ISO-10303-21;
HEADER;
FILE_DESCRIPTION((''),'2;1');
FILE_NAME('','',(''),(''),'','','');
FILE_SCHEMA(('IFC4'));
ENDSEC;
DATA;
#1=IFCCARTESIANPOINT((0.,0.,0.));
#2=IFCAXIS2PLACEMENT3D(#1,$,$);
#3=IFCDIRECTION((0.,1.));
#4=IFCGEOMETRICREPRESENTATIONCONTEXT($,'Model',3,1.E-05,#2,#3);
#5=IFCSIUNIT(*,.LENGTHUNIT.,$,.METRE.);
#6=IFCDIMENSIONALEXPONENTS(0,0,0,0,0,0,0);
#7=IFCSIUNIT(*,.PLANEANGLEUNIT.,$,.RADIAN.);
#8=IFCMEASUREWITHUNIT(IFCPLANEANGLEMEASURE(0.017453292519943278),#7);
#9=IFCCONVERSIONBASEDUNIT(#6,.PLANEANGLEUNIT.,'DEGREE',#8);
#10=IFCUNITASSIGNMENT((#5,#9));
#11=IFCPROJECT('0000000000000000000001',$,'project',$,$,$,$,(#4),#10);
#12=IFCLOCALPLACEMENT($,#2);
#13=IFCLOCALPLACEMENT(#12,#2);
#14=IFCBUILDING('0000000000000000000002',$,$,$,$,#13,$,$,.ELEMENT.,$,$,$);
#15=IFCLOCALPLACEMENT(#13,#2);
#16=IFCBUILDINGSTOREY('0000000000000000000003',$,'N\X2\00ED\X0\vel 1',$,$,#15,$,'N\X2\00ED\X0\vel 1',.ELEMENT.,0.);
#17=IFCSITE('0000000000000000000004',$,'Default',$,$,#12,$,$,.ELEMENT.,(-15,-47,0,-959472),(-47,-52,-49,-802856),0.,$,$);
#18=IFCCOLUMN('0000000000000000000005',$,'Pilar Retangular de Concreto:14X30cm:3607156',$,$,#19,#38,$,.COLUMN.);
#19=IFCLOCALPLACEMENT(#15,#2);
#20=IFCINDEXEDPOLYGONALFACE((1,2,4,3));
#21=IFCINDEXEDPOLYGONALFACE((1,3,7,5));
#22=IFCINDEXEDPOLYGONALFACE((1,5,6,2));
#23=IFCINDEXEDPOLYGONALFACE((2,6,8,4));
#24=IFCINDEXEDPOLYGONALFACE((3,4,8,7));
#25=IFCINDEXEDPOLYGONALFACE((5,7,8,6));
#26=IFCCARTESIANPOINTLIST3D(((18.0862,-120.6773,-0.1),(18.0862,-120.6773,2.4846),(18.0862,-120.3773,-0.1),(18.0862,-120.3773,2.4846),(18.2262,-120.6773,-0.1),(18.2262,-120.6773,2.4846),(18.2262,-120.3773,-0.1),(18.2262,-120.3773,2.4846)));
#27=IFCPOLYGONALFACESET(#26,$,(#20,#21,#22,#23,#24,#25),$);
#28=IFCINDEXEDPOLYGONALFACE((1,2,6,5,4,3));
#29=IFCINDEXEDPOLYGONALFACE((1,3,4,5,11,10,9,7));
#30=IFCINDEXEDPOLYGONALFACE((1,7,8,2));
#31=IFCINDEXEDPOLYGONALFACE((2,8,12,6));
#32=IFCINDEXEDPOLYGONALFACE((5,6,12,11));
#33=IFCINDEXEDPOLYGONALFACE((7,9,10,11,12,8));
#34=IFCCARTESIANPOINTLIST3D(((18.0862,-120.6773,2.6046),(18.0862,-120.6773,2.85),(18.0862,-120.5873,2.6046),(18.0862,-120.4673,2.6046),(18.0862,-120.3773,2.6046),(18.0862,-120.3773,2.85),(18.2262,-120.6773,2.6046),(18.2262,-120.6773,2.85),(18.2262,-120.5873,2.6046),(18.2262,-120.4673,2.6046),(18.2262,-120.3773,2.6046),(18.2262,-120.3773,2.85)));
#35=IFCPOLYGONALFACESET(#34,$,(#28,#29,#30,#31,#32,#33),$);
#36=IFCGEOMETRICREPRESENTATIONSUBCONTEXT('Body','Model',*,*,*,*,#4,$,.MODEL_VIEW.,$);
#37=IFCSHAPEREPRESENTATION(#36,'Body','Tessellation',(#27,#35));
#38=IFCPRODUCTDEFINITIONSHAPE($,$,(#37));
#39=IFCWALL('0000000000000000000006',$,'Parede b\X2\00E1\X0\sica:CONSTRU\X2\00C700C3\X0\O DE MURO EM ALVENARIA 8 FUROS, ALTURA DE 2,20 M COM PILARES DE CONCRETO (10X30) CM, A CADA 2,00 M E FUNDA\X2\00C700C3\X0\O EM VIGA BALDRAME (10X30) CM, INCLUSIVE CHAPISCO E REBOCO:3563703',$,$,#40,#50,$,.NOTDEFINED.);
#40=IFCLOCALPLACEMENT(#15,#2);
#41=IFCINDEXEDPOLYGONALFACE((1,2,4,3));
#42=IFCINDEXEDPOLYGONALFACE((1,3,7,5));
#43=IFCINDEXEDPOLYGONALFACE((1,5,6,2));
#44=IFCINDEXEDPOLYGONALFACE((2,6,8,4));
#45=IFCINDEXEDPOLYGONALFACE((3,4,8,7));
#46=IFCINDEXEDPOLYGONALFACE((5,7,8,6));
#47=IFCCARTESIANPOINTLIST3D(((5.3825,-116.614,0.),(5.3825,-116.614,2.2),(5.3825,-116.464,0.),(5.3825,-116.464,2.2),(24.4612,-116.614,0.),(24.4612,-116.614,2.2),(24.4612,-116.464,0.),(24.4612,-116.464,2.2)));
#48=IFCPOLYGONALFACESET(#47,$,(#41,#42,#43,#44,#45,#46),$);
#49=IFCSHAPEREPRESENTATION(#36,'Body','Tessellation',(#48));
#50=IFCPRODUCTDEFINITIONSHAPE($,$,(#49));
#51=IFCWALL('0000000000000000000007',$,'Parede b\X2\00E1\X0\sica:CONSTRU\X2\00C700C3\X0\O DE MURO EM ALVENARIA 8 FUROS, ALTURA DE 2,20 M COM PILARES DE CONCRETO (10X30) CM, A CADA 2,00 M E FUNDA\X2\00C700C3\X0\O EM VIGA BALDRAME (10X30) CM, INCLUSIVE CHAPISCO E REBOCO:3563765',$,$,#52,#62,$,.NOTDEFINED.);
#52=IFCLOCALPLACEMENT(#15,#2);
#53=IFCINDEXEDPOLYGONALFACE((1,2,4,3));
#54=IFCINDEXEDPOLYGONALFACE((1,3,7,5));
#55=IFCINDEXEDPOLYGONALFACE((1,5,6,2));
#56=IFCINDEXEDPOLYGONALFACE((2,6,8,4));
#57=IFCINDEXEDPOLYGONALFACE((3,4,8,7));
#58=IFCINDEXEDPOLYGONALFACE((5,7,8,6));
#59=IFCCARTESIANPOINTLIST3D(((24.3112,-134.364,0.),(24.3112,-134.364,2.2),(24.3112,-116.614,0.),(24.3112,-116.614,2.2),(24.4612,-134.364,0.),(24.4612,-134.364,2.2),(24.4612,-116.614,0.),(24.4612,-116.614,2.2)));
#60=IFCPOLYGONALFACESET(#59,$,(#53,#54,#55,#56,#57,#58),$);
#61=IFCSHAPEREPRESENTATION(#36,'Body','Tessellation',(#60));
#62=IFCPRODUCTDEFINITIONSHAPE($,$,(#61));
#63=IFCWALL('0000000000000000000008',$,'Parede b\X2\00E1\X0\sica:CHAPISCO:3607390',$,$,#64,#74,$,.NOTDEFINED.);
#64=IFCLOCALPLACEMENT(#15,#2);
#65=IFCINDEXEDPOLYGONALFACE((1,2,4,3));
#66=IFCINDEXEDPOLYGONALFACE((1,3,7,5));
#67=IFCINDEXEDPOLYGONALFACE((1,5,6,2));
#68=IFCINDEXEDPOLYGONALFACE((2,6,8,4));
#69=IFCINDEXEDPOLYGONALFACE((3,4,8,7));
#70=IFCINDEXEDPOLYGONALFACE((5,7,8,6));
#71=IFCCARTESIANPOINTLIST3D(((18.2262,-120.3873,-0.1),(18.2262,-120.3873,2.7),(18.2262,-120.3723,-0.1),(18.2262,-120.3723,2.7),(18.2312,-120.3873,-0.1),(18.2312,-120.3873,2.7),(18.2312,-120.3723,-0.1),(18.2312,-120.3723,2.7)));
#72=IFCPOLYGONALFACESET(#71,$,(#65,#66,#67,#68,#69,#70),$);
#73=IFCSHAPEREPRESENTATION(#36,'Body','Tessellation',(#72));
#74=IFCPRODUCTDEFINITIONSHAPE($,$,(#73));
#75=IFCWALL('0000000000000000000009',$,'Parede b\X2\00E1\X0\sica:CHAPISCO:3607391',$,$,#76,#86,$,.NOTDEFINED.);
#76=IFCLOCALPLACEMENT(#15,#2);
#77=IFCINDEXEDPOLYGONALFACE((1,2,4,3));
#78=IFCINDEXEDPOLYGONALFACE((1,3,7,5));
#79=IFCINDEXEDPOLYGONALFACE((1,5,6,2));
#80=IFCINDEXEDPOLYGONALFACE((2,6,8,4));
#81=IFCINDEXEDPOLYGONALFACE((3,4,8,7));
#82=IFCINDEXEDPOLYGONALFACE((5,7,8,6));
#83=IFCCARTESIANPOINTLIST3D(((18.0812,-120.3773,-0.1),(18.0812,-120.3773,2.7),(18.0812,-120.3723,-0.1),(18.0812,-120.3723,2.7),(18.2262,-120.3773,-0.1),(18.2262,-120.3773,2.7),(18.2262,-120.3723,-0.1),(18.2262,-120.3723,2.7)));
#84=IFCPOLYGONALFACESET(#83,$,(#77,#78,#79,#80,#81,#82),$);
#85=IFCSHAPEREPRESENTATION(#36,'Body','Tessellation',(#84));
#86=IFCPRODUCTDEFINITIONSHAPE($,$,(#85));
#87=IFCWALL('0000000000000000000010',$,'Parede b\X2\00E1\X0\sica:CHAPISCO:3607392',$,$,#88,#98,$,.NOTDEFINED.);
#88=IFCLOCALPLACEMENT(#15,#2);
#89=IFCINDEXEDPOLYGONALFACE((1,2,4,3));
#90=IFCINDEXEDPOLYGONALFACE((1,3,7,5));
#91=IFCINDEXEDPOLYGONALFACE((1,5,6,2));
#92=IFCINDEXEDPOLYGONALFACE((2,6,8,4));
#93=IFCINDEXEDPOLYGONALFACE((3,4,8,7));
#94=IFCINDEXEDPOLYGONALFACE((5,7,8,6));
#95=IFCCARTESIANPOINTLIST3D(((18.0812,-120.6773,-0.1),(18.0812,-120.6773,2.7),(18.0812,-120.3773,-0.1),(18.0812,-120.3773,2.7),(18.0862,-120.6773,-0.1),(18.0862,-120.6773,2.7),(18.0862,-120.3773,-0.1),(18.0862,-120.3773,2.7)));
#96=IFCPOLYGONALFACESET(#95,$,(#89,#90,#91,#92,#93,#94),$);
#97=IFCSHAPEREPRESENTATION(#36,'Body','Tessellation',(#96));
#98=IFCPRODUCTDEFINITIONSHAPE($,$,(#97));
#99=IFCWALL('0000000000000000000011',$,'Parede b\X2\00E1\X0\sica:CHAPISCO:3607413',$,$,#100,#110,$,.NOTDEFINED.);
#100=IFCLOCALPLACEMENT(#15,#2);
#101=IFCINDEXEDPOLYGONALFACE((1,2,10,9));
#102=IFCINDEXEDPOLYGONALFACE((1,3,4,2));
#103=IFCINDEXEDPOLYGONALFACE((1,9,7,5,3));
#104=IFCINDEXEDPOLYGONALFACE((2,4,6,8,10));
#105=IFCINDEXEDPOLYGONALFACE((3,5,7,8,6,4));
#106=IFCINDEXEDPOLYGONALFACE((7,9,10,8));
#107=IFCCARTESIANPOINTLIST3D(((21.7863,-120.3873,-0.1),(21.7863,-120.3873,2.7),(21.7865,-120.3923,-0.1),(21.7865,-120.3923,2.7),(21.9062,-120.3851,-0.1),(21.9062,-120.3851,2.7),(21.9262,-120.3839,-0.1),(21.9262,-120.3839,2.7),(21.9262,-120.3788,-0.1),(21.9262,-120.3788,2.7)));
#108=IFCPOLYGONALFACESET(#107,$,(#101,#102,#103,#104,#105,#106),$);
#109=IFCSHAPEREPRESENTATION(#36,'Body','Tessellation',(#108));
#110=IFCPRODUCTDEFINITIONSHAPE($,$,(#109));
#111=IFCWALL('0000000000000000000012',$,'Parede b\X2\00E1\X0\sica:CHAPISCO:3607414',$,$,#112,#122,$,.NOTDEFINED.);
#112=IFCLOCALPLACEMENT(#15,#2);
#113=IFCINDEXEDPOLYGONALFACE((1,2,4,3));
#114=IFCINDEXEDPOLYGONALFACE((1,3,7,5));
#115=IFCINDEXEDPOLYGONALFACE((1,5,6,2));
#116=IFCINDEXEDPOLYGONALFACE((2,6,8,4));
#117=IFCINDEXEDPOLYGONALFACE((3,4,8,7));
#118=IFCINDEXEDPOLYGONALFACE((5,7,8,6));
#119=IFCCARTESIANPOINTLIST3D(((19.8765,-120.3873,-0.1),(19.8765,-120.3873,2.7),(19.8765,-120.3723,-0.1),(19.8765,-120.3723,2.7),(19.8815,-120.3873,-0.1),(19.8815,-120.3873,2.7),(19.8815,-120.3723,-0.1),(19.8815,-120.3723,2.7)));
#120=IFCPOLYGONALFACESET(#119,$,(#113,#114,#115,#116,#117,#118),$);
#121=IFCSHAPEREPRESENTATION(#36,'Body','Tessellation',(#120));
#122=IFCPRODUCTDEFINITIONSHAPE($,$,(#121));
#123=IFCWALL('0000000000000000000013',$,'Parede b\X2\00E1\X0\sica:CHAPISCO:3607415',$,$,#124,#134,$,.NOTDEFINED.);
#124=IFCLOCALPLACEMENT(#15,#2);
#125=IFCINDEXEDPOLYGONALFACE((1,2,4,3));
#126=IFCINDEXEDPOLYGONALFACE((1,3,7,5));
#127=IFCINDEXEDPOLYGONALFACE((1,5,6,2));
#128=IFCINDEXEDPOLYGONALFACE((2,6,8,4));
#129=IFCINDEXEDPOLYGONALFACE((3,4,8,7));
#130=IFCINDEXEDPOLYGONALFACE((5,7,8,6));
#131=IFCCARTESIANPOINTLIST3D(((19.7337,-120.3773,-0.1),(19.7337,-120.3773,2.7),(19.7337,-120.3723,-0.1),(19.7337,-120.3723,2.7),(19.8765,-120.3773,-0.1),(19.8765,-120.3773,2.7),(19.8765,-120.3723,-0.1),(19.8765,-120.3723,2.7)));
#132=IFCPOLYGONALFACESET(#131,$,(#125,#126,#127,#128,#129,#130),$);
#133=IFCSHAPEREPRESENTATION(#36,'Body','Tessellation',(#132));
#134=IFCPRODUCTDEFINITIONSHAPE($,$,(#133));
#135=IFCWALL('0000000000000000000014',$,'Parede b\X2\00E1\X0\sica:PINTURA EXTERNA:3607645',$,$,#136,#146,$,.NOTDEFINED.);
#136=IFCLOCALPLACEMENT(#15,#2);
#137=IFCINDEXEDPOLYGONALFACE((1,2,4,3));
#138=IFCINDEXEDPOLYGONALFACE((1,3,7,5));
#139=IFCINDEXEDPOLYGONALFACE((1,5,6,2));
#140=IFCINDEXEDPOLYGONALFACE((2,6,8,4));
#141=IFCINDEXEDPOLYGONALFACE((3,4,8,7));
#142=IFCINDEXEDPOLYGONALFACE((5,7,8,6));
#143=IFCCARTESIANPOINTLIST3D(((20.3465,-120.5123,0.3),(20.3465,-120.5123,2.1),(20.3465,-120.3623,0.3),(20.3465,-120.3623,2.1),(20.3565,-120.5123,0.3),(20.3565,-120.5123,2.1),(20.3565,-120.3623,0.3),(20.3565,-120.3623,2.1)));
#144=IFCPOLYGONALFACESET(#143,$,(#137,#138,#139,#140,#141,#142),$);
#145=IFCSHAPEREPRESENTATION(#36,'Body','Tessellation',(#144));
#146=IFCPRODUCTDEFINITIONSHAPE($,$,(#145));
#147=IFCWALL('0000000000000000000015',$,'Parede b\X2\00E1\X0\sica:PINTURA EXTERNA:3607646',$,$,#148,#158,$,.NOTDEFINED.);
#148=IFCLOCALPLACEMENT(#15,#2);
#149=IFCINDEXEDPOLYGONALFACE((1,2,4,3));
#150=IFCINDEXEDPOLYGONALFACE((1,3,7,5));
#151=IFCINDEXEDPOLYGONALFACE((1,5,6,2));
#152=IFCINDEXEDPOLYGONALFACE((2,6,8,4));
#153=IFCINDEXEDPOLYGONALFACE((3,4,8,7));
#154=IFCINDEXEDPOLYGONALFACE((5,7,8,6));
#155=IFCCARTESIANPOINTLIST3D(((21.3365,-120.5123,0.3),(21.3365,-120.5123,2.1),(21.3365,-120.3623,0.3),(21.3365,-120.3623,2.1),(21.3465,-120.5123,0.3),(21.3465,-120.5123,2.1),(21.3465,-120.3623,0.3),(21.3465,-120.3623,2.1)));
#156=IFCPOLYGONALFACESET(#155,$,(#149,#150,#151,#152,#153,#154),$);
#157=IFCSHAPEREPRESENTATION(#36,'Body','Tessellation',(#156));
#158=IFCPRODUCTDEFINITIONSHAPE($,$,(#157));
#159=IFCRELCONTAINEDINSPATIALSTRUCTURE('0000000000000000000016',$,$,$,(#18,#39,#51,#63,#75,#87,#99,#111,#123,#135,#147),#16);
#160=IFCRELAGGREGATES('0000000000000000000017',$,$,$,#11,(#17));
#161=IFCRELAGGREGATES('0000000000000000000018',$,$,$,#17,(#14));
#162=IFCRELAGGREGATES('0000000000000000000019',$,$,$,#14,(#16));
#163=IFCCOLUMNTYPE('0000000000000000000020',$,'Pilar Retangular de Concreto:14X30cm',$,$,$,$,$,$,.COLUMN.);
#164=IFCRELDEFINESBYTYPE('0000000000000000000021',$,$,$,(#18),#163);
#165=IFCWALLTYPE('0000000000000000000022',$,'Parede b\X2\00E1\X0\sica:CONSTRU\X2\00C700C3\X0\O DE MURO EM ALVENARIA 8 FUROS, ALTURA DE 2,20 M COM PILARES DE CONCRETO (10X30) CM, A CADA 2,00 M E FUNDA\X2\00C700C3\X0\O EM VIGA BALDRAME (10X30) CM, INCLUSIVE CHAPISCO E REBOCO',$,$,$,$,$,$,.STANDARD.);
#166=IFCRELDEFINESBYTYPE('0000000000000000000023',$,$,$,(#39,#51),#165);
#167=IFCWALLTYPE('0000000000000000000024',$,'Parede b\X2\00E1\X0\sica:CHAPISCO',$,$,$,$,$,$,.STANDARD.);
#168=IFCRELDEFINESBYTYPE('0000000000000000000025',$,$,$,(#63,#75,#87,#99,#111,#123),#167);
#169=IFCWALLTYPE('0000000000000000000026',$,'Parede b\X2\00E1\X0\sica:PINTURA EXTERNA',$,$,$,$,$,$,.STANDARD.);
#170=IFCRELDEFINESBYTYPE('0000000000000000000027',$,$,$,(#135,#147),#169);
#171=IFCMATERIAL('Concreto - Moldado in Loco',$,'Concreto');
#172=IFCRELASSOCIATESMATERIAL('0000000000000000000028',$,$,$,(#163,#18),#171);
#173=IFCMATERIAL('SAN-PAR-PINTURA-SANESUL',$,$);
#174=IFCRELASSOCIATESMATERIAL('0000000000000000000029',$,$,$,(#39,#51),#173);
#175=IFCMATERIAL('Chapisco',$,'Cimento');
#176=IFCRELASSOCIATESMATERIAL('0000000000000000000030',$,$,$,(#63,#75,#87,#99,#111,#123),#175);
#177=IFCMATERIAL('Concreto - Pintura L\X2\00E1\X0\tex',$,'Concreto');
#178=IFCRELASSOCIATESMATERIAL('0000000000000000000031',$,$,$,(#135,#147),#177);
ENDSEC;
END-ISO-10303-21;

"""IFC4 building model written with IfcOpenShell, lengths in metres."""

from ifc_helpers import new_model, entity, si_unit, converted_unit, direction, frame, origin, place, context, subcontext, project, spatial, indexed_curve, outline, extrude, source, transform, mapped, material, type_object, type_shapes, element, save


model = new_model("IFC4")

# Units and contexts
model_context = context("Model", 3, precision=1e-05, world=origin(), true_north=direction((0.0, 1.0)))
body_context = subcontext(model_context, "Body", "Model", "MODEL_VIEW")
ifc_project = project(units=[si_unit("LENGTHUNIT", "METRE"), converted_unit("PLANEANGLEUNIT", "DEGREE", entity("IfcPlaneAngleMeasure", 0.017453292519943278), si_unit("PLANEANGLEUNIT", "RADIAN"), dimensions=[0, 0, 0, 0, 0, 0, 0])], contexts=[model_context])

# Site, building, storey
site_placement = place(None, origin())
site = spatial("IfcSite", under=ifc_project, at=site_placement, Name="Default", CompositionType="ELEMENT", RefLatitude=(-15, -47, 0, -959472), RefLongitude=(-47, -52, -49, -802856), RefElevation=0.0)
building_placement = place(site_placement, origin())
building = spatial("IfcBuilding", under=site, at=building_placement, CompositionType="ELEMENT")
storey_placement = place(building_placement, origin())
storey = spatial("IfcBuildingStorey", under=building, at=storey_placement, Name="Nível 1", LongName="Nível 1", CompositionType="ELEMENT", Elevation=0.0)

# Column
ifc_material_1 = material(Name="Concreto - Moldado in Loco", Category="Concreto")
column_type = type_object("IfcColumnType", Name="Pilar Retangular de Concreto:14X30cm", PredefinedType="COLUMN", material=ifc_material_1)
shared_shape_1 = source(origin(), body_context, "Body", "SweptSolid", [
    extrude(outline(indexed_curve([(-1.2923, -0.15), (1.2923, -0.15), (1.2923, 0.15), (-1.2923, 0.15), (-1.2923, -0.15)], self_intersect=False)), frame((18.0862, -120.5273, 1.1923), z_axis=(1.0, 0.0, 0.0), x_axis=(0.0, 0.0, 1.0)), (0.0, 0.0, 1.0), 0.14),
    extrude(outline(indexed_curve([(-0.1636, -0.15), (0.0818, -0.15), (0.0818, -0.06), (0.0818, 0.06), (0.0818, 0.15), (-0.1636, 0.15), (-0.1636, -0.15)], self_intersect=False)), frame((18.0862, -120.5273, 2.6864), z_axis=(1.0, 0.0, 0.0), x_axis=(0.0, 0.0, -1.0)), (0.0, 0.0, 1.0), 0.14),
])
type_shapes(column_type, [shared_shape_1])
column_placement = place(storey_placement, origin())
element("IfcColumn", 1, at=column_placement, inside=storey, type_object=column_type, material=ifc_material_1, Name="Pilar Retangular de Concreto:14X30cm:3607156", PredefinedType="COLUMN", context=body_context, shape_type="MappedRepresentation", body=[
    mapped(shared_shape_1, transform((0.0, 0.0, 0.0), scale=1.0)),
])

# Walls
ifc_material_2 = material(Name="SAN-PAR-PINTURA-SANESUL")
wall_type_1 = type_object("IfcWallType", Name="Parede básica:CONSTRUÇÃO DE MURO EM ALVENARIA 8 FUROS, ALTURA DE 2,20 M COM PILARES DE CONCRETO (10X30) CM, A CADA 2,00 M E FUNDAÇÃO EM VIGA BALDRAME (10X30) CM, INCLUSIVE CHAPISCO E REBOCO", PredefinedType="STANDARD")
wall_1_placement = place(storey_placement, frame((5.3825, -116.539, 0.0)))
element("IfcWall", 2, at=wall_1_placement, inside=storey, type_object=wall_type_1, material=ifc_material_2, Name="Parede básica:CONSTRUÇÃO DE MURO EM ALVENARIA 8 FUROS, ALTURA DE 2,20 M COM PILARES DE CONCRETO (10X30) CM, A CADA 2,00 M E FUNDAÇÃO EM VIGA BALDRAME (10X30) CM, INCLUSIVE CHAPISCO E REBOCO:3563703", PredefinedType="NOTDEFINED", context=body_context, shape_type="SweptSolid", body=[
    extrude(outline(indexed_curve([(19.0787, 0.075), (0.0, 0.075), (0.0, -0.075), (19.0787, -0.075), (19.0787, 0.075)], self_intersect=False)), origin(), (0.0, 0.0, 1.0), 2.2),
])
wall_2_placement = place(storey_placement, frame((24.3862, -116.614, 0.0), z_axis=(0.0, 0.0, 1.0), x_axis=(0.0, -1.0, 0.0)))
element("IfcWall", 3, at=wall_2_placement, inside=storey, type_object=wall_type_1, material=ifc_material_2, Name="Parede básica:CONSTRUÇÃO DE MURO EM ALVENARIA 8 FUROS, ALTURA DE 2,20 M COM PILARES DE CONCRETO (10X30) CM, A CADA 2,00 M E FUNDAÇÃO EM VIGA BALDRAME (10X30) CM, INCLUSIVE CHAPISCO E REBOCO:3563765", PredefinedType="NOTDEFINED", context=body_context, shape_type="SweptSolid", body=[
    extrude(outline(indexed_curve([(17.75, 0.075), (0.0, 0.075), (0.0, -0.075), (17.75, -0.075), (17.75, 0.075)], self_intersect=False)), origin(), (0.0, 0.0, 1.0), 2.2),
])
ifc_material_3 = material(Name="Chapisco", Category="Cimento")
wall_type_2 = type_object("IfcWallType", Name="Parede básica:CHAPISCO", PredefinedType="STANDARD")
wall_3_placement = place(storey_placement, frame((18.2287, -120.3873, -0.1), z_axis=(0.0, 0.0, 1.0), x_axis=(0.0, 1.0, 0.0)))
element("IfcWall", 4, at=wall_3_placement, inside=storey, type_object=wall_type_2, material=ifc_material_3, Name="Parede básica:CHAPISCO:3607390", PredefinedType="NOTDEFINED", context=body_context, shape_type="SweptSolid", body=[
    extrude(outline(indexed_curve([(0.015, 0.0025), (0.0, 0.0025), (0.0, -0.0025), (0.015, -0.0025), (0.015, 0.0025)], self_intersect=False)), origin(), (0.0, 0.0, 1.0), 2.8),
])
wall_4_placement = place(storey_placement, frame((18.2262, -120.3748, -0.1), z_axis=(0.0, 0.0, 1.0), x_axis=(-1.0, 0.0, 0.0)))
element("IfcWall", 5, at=wall_4_placement, inside=storey, type_object=wall_type_2, material=ifc_material_3, Name="Parede básica:CHAPISCO:3607391", PredefinedType="NOTDEFINED", context=body_context, shape_type="SweptSolid", body=[
    extrude(outline(indexed_curve([(0.145, 0.0025), (0.0, 0.0025), (0.0, -0.0025), (0.145, -0.0025), (0.145, 0.0025)], self_intersect=False)), origin(), (0.0, 0.0, 1.0), 2.8),
])
wall_5_placement = place(storey_placement, frame((18.0837, -120.3773, -0.1), z_axis=(0.0, 0.0, 1.0), x_axis=(0.0, -1.0, 0.0)))
element("IfcWall", 6, at=wall_5_placement, inside=storey, type_object=wall_type_2, material=ifc_material_3, Name="Parede básica:CHAPISCO:3607392", PredefinedType="NOTDEFINED", context=body_context, shape_type="SweptSolid", body=[
    extrude(outline(indexed_curve([(0.3, 0.0025), (0.0, 0.0025), (0.0, -0.0025), (0.3, -0.0025), (0.3, 0.0025)], self_intersect=False)), origin(), (0.0, 0.0, 1.0), 2.8),
])
wall_6_placement = place(storey_placement, frame((21.9264, -120.3813, -0.1), z_axis=(0.0, 0.0, 1.0), x_axis=(-0.998177, -0.060352, 0.0)))
element("IfcWall", 7, at=wall_6_placement, inside=storey, type_object=wall_type_2, material=ifc_material_3, Name="Parede básica:CHAPISCO:3607413", PredefinedType="NOTDEFINED", context=body_context, shape_type="SweptSolid", body=[
    extrude(outline(indexed_curve([(0.1401, -0.0025), (0.1403, 0.0025), (0.0203, 0.0025), (0.0003, 0.0025), (0.0, -0.0025), (0.1401, -0.0025)], self_intersect=False)), origin(), (0.0, 0.0, 1.0), 2.8),
])
wall_7_placement = place(storey_placement, frame((19.879, -120.3873, -0.1), z_axis=(0.0, 0.0, 1.0), x_axis=(0.0, 1.0, 0.0)))
element("IfcWall", 8, at=wall_7_placement, inside=storey, type_object=wall_type_2, material=ifc_material_3, Name="Parede básica:CHAPISCO:3607414", PredefinedType="NOTDEFINED", context=body_context, shape_type="SweptSolid", body=[
    extrude(outline(indexed_curve([(0.015, 0.0025), (0.0, 0.0025), (0.0, -0.0025), (0.015, -0.0025), (0.015, 0.0025)], self_intersect=False)), origin(), (0.0, 0.0, 1.0), 2.8),
])
wall_8_placement = place(storey_placement, frame((19.8765, -120.3748, -0.1), z_axis=(0.0, 0.0, 1.0), x_axis=(-1.0, 0.0, 0.0)))
element("IfcWall", 9, at=wall_8_placement, inside=storey, type_object=wall_type_2, material=ifc_material_3, Name="Parede básica:CHAPISCO:3607415", PredefinedType="NOTDEFINED", context=body_context, shape_type="SweptSolid", body=[
    extrude(outline(indexed_curve([(0.1428, 0.0025), (0.0, 0.0025), (0.0, -0.0025), (0.1428, -0.0025), (0.1428, 0.0025)], self_intersect=False)), origin(), (0.0, 0.0, 1.0), 2.8),
])
ifc_material_4 = material(Name="Concreto - Pintura Látex", Category="Concreto")
wall_type_3 = type_object("IfcWallType", Name="Parede básica:PINTURA EXTERNA", PredefinedType="STANDARD")
wall_9_placement = place(storey_placement, frame((20.3515, -120.3623, 0.3), z_axis=(0.0, 0.0, 1.0), x_axis=(0.0, -1.0, 0.0)))
element("IfcWall", 10, at=wall_9_placement, inside=storey, type_object=wall_type_3, material=ifc_material_4, Name="Parede básica:PINTURA EXTERNA:3607645", PredefinedType="NOTDEFINED", context=body_context, shape_type="SweptSolid", body=[
    extrude(outline(indexed_curve([(0.15, 0.005), (0.0, 0.005), (0.0, -0.005), (0.15, -0.005), (0.15, 0.005)], self_intersect=False)), origin(), (0.0, 0.0, 1.0), 1.8),
])
wall_10_placement = place(storey_placement, frame((21.3415, -120.3623, 0.3), z_axis=(0.0, 0.0, 1.0), x_axis=(0.0, -1.0, 0.0)))
element("IfcWall", 11, at=wall_10_placement, inside=storey, type_object=wall_type_3, material=ifc_material_4, Name="Parede básica:PINTURA EXTERNA:3607646", PredefinedType="NOTDEFINED", context=body_context, shape_type="SweptSolid", body=[
    extrude(outline(indexed_curve([(0.15, 0.005), (0.0, 0.005), (0.0, -0.005), (0.15, -0.005), (0.15, 0.005)], self_intersect=False)), origin(), (0.0, 0.0, 1.0), 1.8),
])

save(model, "model.ifc")
